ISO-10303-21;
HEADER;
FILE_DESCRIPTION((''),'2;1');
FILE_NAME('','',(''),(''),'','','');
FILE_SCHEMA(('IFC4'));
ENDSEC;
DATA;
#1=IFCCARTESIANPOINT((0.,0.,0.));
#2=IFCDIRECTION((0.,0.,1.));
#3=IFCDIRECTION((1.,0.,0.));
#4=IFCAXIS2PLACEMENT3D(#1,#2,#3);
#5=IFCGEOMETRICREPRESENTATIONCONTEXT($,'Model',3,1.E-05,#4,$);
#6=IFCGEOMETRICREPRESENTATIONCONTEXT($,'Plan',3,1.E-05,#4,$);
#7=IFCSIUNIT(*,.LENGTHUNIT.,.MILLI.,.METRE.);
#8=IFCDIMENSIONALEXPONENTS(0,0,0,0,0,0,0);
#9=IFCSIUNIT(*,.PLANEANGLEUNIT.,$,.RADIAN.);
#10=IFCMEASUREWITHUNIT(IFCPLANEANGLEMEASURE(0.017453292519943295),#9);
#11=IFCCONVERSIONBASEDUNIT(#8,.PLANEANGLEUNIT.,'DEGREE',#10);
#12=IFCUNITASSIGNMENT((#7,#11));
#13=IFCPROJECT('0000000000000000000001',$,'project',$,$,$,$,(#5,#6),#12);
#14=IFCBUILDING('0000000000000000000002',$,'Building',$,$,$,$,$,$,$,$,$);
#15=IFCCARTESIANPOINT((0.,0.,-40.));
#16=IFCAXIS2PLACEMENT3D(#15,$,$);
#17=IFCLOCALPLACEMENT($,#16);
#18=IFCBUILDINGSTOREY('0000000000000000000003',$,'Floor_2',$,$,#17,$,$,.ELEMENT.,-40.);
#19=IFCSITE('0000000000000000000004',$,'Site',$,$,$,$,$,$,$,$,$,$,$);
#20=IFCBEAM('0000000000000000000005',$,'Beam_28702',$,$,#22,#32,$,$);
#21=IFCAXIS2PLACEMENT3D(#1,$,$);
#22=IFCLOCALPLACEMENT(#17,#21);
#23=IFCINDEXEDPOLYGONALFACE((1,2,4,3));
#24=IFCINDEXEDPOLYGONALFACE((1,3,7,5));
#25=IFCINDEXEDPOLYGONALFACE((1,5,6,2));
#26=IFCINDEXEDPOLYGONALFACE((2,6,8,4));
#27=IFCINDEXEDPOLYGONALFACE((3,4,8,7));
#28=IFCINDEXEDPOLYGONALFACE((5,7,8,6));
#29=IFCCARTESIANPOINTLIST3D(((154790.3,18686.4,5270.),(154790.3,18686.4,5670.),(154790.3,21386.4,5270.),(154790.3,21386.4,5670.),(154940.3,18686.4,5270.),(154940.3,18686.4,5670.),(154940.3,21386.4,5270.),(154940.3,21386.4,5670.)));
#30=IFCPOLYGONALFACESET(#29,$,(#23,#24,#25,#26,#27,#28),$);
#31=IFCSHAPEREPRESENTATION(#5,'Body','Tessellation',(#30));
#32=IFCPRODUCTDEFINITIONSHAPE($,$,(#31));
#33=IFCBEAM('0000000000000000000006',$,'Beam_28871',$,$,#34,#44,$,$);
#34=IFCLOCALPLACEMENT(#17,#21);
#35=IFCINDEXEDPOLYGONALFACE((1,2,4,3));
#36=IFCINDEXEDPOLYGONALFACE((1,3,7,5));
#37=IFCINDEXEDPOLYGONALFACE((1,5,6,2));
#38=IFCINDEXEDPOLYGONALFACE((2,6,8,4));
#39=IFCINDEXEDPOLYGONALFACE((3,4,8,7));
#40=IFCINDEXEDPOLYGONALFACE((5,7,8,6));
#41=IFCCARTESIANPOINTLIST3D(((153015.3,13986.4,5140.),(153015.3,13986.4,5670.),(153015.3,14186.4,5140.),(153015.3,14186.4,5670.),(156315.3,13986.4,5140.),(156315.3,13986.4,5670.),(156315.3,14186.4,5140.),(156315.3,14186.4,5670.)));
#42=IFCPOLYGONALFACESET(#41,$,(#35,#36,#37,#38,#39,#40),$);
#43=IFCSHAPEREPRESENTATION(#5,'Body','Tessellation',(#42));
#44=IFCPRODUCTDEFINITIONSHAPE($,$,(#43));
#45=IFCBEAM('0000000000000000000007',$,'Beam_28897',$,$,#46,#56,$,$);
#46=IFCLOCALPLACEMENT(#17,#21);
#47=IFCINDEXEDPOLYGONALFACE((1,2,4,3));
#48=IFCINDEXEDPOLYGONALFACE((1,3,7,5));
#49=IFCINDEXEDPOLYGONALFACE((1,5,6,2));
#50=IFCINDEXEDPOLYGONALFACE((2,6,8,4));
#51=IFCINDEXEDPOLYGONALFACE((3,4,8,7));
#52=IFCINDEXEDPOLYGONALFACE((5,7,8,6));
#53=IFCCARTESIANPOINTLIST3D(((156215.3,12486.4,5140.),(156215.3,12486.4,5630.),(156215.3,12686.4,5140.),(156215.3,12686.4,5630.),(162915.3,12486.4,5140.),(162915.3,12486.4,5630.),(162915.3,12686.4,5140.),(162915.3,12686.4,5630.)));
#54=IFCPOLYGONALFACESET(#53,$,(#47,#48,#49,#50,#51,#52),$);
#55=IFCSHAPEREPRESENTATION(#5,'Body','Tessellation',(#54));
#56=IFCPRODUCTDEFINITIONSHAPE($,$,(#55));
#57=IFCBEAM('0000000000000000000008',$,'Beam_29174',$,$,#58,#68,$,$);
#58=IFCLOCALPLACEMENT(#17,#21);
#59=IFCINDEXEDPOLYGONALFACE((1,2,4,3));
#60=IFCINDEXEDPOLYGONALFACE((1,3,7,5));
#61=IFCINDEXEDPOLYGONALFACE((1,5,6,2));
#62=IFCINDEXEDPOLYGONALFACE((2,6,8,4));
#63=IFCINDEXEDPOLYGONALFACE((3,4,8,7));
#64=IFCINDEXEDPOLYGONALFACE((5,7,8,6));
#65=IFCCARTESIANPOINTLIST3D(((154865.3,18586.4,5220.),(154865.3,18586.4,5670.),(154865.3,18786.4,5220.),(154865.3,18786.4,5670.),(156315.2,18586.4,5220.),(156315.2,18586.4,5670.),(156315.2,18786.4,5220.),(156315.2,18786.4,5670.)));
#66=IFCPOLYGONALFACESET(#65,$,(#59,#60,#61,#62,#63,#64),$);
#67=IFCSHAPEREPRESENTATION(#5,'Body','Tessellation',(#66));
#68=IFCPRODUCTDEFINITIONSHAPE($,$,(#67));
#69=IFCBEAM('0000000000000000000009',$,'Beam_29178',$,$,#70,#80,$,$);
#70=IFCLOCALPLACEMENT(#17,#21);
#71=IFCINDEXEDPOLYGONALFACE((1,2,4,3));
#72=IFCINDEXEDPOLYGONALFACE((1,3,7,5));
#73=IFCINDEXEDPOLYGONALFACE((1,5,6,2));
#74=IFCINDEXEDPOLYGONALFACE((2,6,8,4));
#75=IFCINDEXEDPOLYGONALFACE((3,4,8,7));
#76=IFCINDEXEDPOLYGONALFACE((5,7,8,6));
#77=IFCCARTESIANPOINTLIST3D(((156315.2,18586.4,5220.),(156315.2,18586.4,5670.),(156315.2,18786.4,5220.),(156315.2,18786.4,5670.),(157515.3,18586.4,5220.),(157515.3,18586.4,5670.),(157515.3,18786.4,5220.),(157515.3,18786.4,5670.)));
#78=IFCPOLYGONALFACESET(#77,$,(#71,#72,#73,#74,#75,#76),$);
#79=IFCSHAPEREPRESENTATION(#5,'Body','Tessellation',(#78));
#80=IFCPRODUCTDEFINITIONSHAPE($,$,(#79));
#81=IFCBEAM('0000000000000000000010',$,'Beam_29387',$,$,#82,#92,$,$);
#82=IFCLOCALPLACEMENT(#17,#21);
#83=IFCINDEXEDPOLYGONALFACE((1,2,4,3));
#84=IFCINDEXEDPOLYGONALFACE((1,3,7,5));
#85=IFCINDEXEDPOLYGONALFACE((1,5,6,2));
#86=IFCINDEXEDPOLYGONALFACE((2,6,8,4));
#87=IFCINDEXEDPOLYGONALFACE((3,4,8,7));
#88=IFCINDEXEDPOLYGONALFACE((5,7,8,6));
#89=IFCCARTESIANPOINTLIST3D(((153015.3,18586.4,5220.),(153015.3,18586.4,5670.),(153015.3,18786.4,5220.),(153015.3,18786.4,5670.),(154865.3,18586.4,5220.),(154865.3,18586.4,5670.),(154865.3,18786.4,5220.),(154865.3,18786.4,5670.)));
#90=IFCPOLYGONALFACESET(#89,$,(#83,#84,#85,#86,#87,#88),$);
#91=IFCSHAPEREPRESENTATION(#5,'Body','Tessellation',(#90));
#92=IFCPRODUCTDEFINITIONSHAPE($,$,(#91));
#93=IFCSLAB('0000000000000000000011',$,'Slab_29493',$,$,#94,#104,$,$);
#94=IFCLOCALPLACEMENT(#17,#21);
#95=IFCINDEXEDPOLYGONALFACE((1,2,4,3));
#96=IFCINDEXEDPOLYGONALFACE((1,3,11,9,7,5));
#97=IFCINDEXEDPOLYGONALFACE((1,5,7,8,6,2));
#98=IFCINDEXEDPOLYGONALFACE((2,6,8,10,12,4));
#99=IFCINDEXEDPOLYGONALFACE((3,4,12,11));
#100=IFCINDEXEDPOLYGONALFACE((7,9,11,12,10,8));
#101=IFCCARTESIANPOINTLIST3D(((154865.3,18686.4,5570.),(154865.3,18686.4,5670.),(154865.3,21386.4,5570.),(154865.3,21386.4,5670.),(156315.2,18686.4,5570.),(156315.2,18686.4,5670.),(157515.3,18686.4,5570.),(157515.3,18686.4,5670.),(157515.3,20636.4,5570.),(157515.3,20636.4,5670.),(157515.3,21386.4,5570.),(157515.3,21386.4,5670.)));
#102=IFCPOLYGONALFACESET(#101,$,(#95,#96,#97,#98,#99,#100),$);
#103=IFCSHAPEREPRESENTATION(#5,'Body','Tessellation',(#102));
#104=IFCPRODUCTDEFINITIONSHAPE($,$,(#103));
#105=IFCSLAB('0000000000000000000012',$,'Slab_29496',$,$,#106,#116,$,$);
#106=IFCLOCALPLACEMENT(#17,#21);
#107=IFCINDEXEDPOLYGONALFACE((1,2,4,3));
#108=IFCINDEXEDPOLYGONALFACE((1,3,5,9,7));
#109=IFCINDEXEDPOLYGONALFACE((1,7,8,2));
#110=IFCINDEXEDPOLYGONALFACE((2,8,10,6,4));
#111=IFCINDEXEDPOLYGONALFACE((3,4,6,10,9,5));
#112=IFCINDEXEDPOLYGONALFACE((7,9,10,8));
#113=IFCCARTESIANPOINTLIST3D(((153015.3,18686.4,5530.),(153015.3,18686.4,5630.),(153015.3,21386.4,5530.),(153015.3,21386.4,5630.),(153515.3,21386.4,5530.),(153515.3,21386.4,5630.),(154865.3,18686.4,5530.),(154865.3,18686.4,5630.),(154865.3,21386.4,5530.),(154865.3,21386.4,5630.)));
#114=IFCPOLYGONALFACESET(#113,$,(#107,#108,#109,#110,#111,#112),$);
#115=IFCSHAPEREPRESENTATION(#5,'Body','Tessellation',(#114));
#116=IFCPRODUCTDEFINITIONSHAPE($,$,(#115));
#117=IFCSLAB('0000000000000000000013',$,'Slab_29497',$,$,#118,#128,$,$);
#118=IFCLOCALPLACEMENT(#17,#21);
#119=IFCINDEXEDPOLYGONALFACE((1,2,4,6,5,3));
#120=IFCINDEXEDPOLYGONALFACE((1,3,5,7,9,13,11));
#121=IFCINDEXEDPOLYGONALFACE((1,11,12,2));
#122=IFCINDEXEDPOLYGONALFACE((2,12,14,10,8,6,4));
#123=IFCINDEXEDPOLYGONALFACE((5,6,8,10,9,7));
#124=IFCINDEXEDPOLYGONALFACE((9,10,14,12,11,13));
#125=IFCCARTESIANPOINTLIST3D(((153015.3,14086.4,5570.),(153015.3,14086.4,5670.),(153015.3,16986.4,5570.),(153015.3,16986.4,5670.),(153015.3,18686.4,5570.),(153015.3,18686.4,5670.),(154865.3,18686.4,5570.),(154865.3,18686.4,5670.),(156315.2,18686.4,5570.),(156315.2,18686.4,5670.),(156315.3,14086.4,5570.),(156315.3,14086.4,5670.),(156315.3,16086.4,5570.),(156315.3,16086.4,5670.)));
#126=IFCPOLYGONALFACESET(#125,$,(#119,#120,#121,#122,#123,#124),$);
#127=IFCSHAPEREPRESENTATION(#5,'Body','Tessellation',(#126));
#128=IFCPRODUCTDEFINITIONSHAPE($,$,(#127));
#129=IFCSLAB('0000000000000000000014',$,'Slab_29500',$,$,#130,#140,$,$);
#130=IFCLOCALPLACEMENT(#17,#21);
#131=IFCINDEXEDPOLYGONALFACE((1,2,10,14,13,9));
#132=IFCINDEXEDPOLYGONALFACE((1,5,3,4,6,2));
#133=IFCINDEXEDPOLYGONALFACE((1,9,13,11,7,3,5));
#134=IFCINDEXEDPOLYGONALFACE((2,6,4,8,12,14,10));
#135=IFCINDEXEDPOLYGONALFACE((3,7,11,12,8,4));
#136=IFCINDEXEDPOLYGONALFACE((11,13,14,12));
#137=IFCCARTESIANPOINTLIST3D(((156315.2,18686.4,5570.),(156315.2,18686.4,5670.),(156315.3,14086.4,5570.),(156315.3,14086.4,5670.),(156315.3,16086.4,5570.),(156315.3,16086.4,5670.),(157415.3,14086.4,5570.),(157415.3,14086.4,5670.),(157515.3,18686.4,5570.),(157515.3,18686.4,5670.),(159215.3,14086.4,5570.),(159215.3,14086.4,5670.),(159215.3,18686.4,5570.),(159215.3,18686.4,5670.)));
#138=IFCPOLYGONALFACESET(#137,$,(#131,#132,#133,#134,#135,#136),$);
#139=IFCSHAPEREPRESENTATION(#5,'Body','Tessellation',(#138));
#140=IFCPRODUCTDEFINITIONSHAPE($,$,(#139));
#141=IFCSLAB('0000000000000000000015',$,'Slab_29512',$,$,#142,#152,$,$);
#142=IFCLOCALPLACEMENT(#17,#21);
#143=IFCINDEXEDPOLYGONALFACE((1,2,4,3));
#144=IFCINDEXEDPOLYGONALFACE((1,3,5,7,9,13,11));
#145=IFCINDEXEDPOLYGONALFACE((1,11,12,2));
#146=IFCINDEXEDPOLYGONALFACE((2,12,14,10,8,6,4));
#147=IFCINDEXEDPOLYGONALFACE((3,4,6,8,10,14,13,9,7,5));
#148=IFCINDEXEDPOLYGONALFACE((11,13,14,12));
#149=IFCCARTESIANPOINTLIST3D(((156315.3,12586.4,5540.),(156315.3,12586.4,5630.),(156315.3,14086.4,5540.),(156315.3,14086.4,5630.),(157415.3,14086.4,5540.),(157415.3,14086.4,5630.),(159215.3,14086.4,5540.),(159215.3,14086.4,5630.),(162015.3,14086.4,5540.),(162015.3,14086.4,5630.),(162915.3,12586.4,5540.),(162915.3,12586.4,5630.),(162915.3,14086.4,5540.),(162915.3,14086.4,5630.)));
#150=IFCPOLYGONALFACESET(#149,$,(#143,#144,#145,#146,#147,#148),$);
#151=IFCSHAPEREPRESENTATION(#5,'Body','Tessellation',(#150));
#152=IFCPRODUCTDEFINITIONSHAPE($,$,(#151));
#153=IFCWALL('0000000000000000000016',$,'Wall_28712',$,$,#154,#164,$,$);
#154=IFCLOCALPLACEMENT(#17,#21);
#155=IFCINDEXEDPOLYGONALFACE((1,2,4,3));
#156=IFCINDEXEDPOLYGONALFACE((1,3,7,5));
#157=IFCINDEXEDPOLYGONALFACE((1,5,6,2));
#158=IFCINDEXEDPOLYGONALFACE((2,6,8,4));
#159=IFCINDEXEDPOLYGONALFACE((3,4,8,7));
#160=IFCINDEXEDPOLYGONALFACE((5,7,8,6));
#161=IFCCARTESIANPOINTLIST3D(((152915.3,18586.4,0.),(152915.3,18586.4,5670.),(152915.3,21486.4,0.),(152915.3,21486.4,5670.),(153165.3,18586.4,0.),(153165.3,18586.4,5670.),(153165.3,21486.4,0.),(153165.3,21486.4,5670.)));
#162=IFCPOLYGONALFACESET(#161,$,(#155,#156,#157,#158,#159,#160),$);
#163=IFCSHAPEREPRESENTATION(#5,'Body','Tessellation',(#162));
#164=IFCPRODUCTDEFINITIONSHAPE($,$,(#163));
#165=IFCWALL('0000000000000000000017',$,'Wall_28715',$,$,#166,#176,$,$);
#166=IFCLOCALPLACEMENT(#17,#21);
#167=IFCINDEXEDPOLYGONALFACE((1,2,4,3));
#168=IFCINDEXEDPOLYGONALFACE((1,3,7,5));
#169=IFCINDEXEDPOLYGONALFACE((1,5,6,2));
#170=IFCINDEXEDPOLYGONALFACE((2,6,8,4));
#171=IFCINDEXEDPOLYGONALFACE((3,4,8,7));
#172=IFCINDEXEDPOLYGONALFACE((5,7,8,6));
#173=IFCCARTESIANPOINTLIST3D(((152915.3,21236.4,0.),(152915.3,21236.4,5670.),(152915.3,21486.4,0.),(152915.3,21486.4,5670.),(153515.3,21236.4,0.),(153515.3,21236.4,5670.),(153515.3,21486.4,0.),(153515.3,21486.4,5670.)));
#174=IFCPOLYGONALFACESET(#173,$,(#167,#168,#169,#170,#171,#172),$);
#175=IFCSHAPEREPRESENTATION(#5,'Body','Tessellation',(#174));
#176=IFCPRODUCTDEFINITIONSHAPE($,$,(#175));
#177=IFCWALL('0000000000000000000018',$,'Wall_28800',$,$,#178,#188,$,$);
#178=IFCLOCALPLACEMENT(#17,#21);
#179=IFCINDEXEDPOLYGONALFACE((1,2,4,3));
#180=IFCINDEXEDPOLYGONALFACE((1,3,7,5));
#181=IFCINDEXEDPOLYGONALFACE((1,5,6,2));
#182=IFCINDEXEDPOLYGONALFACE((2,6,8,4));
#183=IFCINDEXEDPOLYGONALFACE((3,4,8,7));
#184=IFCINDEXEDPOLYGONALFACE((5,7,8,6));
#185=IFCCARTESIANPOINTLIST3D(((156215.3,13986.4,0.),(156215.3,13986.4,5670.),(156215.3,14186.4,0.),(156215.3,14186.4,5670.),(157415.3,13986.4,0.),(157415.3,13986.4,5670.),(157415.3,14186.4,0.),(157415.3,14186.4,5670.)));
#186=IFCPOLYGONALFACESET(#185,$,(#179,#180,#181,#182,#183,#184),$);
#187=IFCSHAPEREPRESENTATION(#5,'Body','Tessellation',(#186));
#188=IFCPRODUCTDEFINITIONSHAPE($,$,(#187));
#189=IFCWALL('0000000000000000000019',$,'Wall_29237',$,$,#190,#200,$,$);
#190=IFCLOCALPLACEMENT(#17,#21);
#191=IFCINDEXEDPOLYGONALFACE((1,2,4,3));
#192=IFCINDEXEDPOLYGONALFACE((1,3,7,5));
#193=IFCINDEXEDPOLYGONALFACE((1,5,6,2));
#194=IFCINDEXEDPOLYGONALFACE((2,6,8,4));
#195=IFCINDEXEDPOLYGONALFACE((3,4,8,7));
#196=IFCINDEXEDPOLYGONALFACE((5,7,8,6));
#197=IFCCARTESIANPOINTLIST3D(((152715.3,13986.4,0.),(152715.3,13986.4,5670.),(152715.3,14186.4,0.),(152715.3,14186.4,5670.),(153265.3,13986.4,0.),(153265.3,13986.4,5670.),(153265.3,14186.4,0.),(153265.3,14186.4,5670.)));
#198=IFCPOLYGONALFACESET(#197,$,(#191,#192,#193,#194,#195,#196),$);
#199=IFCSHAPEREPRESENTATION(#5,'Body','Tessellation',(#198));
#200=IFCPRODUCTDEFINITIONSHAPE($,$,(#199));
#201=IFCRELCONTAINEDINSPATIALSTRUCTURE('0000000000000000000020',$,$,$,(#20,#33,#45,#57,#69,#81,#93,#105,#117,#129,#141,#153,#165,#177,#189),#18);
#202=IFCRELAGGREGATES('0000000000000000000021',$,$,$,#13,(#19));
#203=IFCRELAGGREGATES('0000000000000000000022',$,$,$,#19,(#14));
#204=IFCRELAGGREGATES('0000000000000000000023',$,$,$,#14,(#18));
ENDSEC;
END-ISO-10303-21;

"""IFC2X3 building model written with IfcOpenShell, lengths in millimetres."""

from ifc_helpers import new_model, entity, si_unit, converted_unit, frame, origin_with_axes, origin_2d, place, context, project, spatial, polyline, rectangle, outline, extrude, element, save


model = new_model("IFC2X3")

# Units and contexts
model_context = context("Model", 3, precision=1e-05, world=origin_with_axes())
plan_context = context("Plan", 3, precision=1e-05, world=origin_with_axes())
ifc_project = project(units=[si_unit("LENGTHUNIT", "METRE", prefix="MILLI"), converted_unit("PLANEANGLEUNIT", "DEGREE", entity("IfcPlaneAngleMeasure", 0.017453292519943295), si_unit("PLANEANGLEUNIT", "RADIAN"), dimensions=[0, 0, 0, 0, 0, 0, 0])], contexts=[model_context, plan_context])

# Site, building, storey
site = spatial("IfcSite", under=ifc_project, Name="Site")
building = spatial("IfcBuilding", under=site, Name="Building")
storey_placement = place(None, frame((0.0, 0.0, -40.0)))
storey = spatial("IfcBuildingStorey", under=building, at=storey_placement, Name="Floor_2", CompositionType="ELEMENT", Elevation=-40.0)

# Beams
beam_1_placement = place(storey_placement, frame((154865.3, 18686.4, 5470.0), z_axis=(0.0, 2700.0, 0.0), x_axis=(2700.0, 0.0, 0.0)))
element("IfcBeam", 1, at=beam_1_placement, inside=storey, Name="Beam_28702", context=model_context, shape_type="SweptSolid", body=[
    extrude(rectangle(XDim=150.0, YDim=400.0, at=origin_2d()), origin_with_axes(), (0.0, 0.0, 1.0), 2700.0),
])
beam_2_placement = place(storey_placement, frame((153015.3, 14086.4, 5405.0), z_axis=(3299.977218, 0.0, 0.0), x_axis=(0.0, -3299.977218, 0.0)))
element("IfcBeam", 2, at=beam_2_placement, inside=storey, Name="Beam_28871", context=model_context, shape_type="SweptSolid", body=[
    extrude(rectangle(XDim=200.0, YDim=530.0, at=origin_2d()), origin_with_axes(), (0.0, 0.0, 1.0), 3300.0),
])
beam_3_placement = place(storey_placement, frame((156215.3, 12586.4, 5385.0), z_axis=(6699.99307, 0.0, 0.0), x_axis=(0.0, -6699.99307, 0.0)))
element("IfcBeam", 3, at=beam_3_placement, inside=storey, Name="Beam_28897", context=model_context, shape_type="SweptSolid", body=[
    extrude(rectangle(XDim=200.0, YDim=490.0, at=origin_2d()), origin_with_axes(), (0.0, 0.0, 1.0), 6700.0),
])
beam_4_placement = place(storey_placement, frame((154865.3, 18686.4, 5445.0), z_axis=(1449.886102, 0.0, 0.0), x_axis=(0.0, -1449.886102, 0.0)))
element("IfcBeam", 4, at=beam_4_placement, inside=storey, Name="Beam_29174", context=model_context, shape_type="SweptSolid", body=[
    extrude(rectangle(XDim=200.0, YDim=450.0, at=origin_2d()), origin_with_axes(), (0.0, 0.0, 1.0), 1449.9),
])
beam_5_placement = place(storey_placement, frame((156315.2, 18686.4, 5445.0), z_axis=(1200.113898, 0.0, 0.0), x_axis=(0.0, -1200.113898, 0.0)))
element("IfcBeam", 5, at=beam_5_placement, inside=storey, Name="Beam_29178", context=model_context, shape_type="SweptSolid", body=[
    extrude(rectangle(XDim=200.0, YDim=450.0, at=origin_2d()), origin_with_axes(), (0.0, 0.0, 1.0), 1200.1),
])
beam_6_placement = place(storey_placement, frame((153015.3, 18686.4, 5445.0), z_axis=(1850.0, 0.0, 0.0), x_axis=(0.0, -1850.0, 0.0)))
element("IfcBeam", 6, at=beam_6_placement, inside=storey, Name="Beam_29387", context=model_context, shape_type="SweptSolid", body=[
    extrude(rectangle(XDim=200.0, YDim=450.0, at=origin_2d()), origin_with_axes(), (0.0, 0.0, 1.0), 1850.0),
])

# Slabs
slab_1_placement = place(storey_placement, frame((154865.3, 21386.4, 5570.0), z_axis=(0.0, 0.0, 1.0), x_axis=(0.0, -2700.0, 0.0)))
element("IfcSlab", 7, at=slab_1_placement, inside=storey, Name="Slab_29493", context=model_context, shape_type="SweptSolid", body=[
    extrude(outline(polyline([(0.0, 0.0), (2700.0, 0.0), (2700.0, 1449.9), (2700.0, 2650.0), (750.0, 2650.0), (0.0, 2650.0)])), origin_with_axes(), (0.0, 0.0, 1.0), 100.0),
])
slab_2_placement = place(storey_placement, frame((153015.3, 21386.4, 5530.0), z_axis=(0.0, 0.0, 1.0), x_axis=(0.0, -2700.0, 0.0)))
element("IfcSlab", 8, at=slab_2_placement, inside=storey, Name="Slab_29496", context=model_context, shape_type="SweptSolid", body=[
    extrude(outline(polyline([(0.0, 0.0), (2700.0, 0.0), (2700.0, 1850.0), (0.0, 1850.0), (0.0, 500.0)])), origin_with_axes(), (0.0, 0.0, 1.0), 100.0),
])
slab_3_placement = place(storey_placement, frame((153015.3, 18686.4, 5570.0), z_axis=(0.0, 0.0, 1.0), x_axis=(-0.006, -1699.994, 0.0)))
element("IfcSlab", 9, at=slab_3_placement, inside=storey, Name="Slab_29497", context=model_context, shape_type="SweptSolid", body=[
    extrude(outline(polyline([(0.0, 0.0), (1700.0, 0.0), (4600.0, 0.0), (4600.0, 3300.0), (2600.0, 3300.0), (0.0, 3299.9), (0.0, 1850.0)])), origin_with_axes(), (0.0, 0.0, 1.0), 100.0),
])
slab_4_placement = place(storey_placement, frame((156315.2, 18686.4, 5570.0), z_axis=(0.0, 0.0, 1.0), x_axis=(0.108, -2599.994, 0.0)))
element("IfcSlab", 10, at=slab_4_placement, inside=storey, Name="Slab_29500", context=model_context, shape_type="SweptSolid", body=[
    extrude(outline(polyline([(0.0, 0.0), (2600.0, 0.0), (4600.0, -0.1), (4600.0, 1099.9), (4600.1, 2899.9), (0.1, 2900.1), (0.0, 1200.1)])), origin_with_axes(), (0.0, 0.0, 1.0), 100.0),
])
slab_5_placement = place(storey_placement, frame((156315.3, 14086.4, 5540.0), z_axis=(0.0, 0.0, 1.0), x_axis=(0.029, -1500.0, 0.0)))
element("IfcSlab", 11, at=slab_5_placement, inside=storey, Name="Slab_29512", context=model_context, shape_type="SweptSolid", body=[
    extrude(outline(polyline([(0.0, 0.0), (1500.0, 0.0), (1500.1, 6600.0), (0.1, 6600.0), (0.1, 5700.0), (0.1, 2900.0), (0.0, 1100.0)])), origin_with_axes(), (0.0, 0.0, 1.0), 90.0),
])

# Walls
wall_1_placement = place(storey_placement, frame((153040.3, 20036.4, 0.0), z_axis=(0.0, 0.0, 1.0), x_axis=(0.0, 2900.0, 0.0)))
element("IfcWall", 12, at=wall_1_placement, inside=storey, Name="Wall_28712", context=model_context, shape_type="SweptSolid", body=[
    extrude(rectangle(XDim=2900.0, YDim=250.0, at=origin_2d()), origin_with_axes(), (0.0, 0.0, 1.0), 5670.0),
])
wall_2_placement = place(storey_placement, frame((153215.3, 21361.4, 0.0), z_axis=(0.0, 0.0, 1.0), x_axis=(600.0, 0.0, 0.0)))
element("IfcWall", 13, at=wall_2_placement, inside=storey, Name="Wall_28715", context=model_context, shape_type="SweptSolid", body=[
    extrude(rectangle(XDim=600.0, YDim=250.0, at=origin_2d()), origin_with_axes(), (0.0, 0.0, 1.0), 5670.0),
])
wall_3_placement = place(storey_placement, frame((156815.3, 14086.4, 0.0), z_axis=(0.0, 0.0, 1.0), x_axis=(1200.022782, 0.0, 0.0)))
element("IfcWall", 14, at=wall_3_placement, inside=storey, Name="Wall_28800", context=model_context, shape_type="SweptSolid", body=[
    extrude(rectangle(XDim=1200.0, YDim=200.0, at=origin_2d()), origin_with_axes(), (0.0, 0.0, 1.0), 5670.0),
])
wall_4_placement = place(storey_placement, frame((152990.3, 14086.4, 0.0), z_axis=(0.0, 0.0, 1.0), x_axis=(550.0, 0.0, 0.0)))
element("IfcWall", 15, at=wall_4_placement, inside=storey, Name="Wall_29237", context=model_context, shape_type="SweptSolid", body=[
    extrude(rectangle(XDim=550.0, YDim=200.0, at=origin_2d()), origin_with_axes(), (0.0, 0.0, 1.0), 5670.0),
])

save(model, "model.ifc")
